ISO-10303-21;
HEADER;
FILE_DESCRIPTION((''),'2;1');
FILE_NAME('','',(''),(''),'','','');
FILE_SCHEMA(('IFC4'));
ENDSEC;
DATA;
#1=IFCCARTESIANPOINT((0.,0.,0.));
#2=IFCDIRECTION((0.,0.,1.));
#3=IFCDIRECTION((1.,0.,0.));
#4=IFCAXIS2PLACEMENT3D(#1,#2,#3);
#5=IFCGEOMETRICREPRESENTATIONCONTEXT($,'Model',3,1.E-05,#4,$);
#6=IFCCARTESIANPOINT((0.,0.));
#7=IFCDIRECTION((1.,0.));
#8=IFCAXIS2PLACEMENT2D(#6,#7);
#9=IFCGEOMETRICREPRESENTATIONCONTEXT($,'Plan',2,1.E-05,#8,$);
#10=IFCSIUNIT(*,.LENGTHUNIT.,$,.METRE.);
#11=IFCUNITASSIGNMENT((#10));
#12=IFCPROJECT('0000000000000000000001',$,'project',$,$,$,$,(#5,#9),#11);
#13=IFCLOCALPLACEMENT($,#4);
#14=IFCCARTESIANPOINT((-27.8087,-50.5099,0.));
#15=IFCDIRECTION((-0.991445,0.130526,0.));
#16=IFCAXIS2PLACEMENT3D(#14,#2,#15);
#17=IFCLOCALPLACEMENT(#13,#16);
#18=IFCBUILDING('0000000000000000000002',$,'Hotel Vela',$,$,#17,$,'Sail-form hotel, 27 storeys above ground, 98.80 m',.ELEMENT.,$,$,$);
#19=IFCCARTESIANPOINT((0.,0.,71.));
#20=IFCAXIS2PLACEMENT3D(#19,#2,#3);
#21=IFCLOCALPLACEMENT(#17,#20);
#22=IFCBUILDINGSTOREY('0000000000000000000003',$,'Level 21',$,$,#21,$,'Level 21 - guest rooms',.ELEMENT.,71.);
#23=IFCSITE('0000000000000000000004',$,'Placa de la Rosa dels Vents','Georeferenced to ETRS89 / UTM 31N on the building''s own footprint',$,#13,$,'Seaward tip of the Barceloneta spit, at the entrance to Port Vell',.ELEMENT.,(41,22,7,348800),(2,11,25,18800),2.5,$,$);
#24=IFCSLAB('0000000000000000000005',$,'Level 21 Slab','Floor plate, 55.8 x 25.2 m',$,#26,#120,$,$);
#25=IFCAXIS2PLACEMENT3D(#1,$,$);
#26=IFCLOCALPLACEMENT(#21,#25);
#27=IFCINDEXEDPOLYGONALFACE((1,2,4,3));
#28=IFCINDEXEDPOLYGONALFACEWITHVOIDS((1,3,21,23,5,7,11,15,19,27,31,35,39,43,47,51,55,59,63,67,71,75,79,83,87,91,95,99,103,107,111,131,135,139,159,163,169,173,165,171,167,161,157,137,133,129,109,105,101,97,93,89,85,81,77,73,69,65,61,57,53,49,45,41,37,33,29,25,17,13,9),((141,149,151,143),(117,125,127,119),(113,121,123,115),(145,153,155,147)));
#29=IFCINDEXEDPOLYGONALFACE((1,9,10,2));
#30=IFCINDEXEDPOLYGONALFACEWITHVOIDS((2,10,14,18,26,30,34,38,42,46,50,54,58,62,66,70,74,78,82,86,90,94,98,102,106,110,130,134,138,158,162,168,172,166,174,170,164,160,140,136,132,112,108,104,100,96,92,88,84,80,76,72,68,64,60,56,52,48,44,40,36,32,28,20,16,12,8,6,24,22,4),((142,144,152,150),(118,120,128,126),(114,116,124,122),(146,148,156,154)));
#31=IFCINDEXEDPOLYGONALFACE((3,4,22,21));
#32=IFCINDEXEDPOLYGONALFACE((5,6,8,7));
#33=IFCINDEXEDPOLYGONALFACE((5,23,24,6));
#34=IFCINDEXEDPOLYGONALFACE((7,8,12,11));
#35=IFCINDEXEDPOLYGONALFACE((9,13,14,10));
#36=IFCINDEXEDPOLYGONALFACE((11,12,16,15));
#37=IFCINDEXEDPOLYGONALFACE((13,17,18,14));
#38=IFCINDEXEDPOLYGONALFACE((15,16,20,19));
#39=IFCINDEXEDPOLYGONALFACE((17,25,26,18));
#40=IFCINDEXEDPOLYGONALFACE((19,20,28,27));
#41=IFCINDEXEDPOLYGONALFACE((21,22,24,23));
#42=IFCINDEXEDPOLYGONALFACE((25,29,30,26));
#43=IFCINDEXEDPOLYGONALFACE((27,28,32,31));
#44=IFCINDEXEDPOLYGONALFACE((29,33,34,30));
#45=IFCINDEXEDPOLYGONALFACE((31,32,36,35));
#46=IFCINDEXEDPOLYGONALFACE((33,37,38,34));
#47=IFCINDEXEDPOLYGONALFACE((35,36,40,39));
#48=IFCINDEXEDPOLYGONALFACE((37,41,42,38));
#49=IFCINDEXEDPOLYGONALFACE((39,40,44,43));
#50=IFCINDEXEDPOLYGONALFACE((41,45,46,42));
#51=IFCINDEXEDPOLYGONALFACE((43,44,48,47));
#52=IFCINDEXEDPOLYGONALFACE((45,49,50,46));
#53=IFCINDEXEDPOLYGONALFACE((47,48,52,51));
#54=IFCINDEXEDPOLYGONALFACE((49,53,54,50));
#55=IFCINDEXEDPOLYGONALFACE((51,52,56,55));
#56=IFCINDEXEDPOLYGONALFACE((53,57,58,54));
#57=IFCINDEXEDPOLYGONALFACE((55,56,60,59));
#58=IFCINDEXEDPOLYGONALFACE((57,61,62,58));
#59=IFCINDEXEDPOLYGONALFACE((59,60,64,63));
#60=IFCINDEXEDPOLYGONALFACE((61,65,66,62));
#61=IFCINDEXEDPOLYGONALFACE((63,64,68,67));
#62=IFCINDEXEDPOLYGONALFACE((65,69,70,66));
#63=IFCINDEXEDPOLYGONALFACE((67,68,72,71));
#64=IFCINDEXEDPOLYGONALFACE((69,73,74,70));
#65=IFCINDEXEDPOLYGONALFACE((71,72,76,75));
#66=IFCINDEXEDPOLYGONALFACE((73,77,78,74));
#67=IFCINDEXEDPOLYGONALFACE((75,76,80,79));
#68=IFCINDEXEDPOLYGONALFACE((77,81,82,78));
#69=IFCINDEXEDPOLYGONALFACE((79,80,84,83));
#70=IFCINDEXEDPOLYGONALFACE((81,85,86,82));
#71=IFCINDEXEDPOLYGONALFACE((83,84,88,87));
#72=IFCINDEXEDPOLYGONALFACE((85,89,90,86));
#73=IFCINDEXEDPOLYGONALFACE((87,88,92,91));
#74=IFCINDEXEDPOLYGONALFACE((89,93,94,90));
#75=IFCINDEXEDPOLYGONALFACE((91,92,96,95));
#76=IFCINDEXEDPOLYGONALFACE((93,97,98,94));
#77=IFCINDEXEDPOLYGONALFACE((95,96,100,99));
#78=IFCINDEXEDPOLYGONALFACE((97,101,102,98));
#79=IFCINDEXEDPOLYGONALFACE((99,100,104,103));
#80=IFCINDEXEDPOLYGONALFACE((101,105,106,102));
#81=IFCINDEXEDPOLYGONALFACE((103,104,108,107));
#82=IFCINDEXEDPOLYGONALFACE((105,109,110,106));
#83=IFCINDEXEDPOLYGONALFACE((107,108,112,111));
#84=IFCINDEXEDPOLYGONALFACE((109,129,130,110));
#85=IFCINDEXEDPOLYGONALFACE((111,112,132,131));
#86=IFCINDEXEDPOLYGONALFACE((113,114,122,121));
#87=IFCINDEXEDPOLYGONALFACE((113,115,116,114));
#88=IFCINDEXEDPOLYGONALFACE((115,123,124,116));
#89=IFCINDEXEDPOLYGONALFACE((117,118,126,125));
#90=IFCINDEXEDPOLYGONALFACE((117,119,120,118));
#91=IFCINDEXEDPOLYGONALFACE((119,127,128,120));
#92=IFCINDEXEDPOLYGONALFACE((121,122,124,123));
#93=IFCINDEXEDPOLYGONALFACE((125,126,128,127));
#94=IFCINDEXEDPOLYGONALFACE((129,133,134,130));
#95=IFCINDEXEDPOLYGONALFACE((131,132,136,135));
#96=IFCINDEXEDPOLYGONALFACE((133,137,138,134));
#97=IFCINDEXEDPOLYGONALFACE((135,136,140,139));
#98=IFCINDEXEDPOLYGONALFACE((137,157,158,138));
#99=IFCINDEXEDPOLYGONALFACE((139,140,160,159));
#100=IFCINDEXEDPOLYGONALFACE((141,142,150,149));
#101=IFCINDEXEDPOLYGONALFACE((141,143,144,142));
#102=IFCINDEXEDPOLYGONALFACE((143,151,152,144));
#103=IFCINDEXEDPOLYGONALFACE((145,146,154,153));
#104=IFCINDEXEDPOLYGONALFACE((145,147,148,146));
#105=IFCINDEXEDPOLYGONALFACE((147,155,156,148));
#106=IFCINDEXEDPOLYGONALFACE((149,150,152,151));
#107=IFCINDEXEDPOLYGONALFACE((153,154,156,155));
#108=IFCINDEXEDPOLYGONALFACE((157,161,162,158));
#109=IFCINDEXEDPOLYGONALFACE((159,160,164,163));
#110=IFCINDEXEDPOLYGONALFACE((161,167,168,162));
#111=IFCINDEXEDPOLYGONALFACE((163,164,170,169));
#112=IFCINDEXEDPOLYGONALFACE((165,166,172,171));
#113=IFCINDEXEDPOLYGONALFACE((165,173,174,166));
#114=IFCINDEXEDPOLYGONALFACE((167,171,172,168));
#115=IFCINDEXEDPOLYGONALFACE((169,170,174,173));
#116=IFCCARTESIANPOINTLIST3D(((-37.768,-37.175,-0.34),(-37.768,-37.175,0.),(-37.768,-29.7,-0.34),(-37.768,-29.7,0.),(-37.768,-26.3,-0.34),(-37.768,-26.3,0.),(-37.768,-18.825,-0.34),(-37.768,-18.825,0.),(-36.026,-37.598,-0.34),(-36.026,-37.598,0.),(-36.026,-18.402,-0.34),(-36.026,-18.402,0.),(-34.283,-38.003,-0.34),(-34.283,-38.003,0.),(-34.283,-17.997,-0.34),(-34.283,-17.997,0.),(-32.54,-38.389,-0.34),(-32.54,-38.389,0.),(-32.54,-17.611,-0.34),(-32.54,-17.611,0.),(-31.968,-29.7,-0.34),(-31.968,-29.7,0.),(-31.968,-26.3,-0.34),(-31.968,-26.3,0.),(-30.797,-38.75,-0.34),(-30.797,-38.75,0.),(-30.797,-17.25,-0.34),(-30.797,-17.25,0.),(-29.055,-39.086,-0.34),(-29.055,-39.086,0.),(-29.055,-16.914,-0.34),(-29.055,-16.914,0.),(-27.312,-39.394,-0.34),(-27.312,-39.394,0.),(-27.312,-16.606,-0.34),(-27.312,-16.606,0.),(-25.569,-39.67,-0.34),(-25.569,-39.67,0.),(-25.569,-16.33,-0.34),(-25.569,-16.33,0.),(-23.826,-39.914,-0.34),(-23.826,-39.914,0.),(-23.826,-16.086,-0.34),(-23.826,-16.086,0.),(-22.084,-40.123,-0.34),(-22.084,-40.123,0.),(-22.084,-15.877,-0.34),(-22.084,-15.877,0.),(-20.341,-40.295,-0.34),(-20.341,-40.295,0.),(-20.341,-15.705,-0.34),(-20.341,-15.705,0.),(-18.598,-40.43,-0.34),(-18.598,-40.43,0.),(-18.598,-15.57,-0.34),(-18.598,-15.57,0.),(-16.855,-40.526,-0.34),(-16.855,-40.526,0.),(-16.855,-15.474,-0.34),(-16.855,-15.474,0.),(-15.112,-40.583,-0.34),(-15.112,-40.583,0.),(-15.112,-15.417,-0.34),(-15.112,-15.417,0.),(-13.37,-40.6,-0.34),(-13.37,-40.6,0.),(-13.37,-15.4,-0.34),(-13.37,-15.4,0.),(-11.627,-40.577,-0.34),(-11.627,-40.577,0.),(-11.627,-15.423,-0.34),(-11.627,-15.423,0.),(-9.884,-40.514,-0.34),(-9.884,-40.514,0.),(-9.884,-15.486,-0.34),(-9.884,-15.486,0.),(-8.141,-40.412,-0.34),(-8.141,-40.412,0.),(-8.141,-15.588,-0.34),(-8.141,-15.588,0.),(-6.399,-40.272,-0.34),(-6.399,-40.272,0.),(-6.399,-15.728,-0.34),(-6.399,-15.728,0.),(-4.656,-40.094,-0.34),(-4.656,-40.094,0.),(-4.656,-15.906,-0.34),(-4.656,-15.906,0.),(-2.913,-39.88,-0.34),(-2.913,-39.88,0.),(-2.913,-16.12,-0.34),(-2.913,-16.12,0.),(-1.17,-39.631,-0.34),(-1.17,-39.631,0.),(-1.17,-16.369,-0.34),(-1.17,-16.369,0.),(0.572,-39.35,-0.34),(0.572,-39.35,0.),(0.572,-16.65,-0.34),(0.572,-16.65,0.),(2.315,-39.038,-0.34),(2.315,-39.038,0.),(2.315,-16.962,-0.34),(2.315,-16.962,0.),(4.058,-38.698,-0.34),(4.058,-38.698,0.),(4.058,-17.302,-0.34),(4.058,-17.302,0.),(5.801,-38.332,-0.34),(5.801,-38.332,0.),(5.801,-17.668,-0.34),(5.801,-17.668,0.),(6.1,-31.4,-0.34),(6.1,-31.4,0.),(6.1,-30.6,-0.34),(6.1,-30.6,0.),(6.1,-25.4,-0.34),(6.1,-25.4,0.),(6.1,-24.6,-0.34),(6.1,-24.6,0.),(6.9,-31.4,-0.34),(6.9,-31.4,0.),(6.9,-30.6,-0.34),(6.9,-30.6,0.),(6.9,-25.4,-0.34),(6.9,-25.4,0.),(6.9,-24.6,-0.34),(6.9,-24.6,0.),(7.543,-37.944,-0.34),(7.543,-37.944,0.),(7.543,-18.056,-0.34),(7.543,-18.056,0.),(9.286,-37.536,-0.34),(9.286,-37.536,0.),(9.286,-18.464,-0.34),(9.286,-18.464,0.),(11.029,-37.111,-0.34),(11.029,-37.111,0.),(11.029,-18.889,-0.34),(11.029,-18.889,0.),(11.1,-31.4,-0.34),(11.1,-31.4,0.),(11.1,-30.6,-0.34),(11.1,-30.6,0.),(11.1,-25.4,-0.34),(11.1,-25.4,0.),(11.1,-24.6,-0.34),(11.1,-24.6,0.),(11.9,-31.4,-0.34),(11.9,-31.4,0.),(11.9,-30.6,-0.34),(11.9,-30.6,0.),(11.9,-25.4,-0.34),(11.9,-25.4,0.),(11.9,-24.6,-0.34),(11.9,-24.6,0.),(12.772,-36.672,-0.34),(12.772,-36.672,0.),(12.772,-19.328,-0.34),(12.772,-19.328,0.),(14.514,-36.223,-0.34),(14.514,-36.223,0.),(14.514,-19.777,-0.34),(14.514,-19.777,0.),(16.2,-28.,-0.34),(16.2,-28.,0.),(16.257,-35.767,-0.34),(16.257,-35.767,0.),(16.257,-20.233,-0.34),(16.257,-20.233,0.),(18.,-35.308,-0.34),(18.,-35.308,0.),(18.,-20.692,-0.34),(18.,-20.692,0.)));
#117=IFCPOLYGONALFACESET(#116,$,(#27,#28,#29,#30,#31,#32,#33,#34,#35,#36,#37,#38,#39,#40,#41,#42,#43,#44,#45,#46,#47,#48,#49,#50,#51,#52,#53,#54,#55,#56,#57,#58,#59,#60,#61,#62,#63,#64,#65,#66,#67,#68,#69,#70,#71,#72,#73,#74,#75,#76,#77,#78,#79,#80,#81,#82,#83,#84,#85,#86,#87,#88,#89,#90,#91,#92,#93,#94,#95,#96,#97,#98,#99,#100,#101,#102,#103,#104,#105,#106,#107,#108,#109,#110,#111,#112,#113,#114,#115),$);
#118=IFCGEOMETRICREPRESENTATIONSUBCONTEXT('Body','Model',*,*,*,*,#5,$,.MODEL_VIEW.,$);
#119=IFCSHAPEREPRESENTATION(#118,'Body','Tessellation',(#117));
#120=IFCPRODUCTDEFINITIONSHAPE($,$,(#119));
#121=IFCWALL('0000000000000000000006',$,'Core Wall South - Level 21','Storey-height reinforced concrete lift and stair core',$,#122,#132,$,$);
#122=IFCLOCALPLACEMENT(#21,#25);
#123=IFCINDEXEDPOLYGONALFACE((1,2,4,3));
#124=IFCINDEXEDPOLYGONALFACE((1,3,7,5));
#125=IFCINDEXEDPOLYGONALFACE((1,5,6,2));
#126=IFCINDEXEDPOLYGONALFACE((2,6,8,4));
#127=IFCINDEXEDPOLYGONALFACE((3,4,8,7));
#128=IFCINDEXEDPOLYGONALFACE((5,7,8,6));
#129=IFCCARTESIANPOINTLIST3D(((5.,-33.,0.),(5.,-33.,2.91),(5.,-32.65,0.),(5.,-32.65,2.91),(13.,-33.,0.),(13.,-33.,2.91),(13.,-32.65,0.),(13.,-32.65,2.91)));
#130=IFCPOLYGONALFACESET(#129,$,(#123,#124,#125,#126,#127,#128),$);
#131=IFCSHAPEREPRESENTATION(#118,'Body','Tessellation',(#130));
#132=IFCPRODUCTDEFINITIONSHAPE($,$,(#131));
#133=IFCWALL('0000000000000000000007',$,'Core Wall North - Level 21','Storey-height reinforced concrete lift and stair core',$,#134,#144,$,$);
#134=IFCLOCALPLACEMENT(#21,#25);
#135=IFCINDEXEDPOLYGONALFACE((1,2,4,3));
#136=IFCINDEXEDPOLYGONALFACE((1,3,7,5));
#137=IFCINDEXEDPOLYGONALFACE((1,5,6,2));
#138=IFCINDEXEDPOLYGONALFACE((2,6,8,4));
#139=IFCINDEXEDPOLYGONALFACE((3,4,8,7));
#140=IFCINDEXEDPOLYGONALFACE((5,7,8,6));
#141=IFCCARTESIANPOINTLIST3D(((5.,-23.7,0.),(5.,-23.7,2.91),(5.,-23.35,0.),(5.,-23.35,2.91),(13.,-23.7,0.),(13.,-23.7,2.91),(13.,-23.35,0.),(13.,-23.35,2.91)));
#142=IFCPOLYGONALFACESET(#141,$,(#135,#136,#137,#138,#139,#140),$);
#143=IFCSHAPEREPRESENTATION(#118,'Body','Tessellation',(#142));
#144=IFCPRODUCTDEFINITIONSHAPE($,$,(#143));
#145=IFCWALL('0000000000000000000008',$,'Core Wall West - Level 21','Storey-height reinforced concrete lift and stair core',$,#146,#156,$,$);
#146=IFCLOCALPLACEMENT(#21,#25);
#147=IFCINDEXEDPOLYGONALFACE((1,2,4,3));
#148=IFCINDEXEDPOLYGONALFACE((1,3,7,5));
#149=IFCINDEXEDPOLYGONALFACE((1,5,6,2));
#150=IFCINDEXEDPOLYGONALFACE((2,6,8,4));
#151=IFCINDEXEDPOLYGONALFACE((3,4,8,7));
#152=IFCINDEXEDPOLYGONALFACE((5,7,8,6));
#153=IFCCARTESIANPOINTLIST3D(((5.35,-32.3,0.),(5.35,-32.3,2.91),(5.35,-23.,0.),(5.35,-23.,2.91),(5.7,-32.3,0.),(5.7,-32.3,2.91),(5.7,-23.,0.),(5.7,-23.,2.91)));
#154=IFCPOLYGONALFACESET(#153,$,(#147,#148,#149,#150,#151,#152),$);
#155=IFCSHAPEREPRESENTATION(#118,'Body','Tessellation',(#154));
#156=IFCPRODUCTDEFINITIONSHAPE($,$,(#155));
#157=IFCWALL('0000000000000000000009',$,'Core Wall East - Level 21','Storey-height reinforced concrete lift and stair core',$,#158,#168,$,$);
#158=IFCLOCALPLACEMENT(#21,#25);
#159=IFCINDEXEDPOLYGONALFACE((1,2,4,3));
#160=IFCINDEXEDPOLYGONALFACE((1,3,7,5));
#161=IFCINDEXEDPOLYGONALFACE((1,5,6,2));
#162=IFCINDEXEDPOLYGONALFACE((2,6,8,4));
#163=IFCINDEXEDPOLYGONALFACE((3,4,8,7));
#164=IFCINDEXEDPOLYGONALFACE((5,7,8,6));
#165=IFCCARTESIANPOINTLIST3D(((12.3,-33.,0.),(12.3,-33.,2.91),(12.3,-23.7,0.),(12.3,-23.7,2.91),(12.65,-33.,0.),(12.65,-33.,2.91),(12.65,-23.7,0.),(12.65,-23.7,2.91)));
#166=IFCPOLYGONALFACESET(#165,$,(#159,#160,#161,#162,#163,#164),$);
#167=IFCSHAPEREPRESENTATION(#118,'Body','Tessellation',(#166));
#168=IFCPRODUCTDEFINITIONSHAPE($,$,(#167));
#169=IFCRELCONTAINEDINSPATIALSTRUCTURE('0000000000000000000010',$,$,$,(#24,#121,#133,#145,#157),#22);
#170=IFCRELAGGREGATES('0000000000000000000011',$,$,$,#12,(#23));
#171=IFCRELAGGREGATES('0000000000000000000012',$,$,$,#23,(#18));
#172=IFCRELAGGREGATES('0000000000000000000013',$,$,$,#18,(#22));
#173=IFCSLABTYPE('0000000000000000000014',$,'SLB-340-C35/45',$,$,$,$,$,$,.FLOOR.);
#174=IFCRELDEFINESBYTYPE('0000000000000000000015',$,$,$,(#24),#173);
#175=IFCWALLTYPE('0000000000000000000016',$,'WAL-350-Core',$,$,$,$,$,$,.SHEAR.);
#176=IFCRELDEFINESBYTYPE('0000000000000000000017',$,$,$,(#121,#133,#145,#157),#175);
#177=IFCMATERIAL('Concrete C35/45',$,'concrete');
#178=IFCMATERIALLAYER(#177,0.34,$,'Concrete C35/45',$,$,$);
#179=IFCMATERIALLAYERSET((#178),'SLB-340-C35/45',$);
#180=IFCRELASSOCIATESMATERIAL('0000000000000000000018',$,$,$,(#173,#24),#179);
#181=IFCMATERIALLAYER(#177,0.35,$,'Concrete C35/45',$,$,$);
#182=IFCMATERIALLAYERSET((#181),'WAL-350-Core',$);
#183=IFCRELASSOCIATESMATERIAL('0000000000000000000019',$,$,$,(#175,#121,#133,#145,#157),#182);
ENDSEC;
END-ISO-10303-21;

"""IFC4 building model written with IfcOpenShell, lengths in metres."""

from ifc_helpers import new_model, si_unit, frame, origin_with_axes, origin_2d_with_axis, place, context, subcontext, project, spatial, line, indexed_curve, outline, extrude, material, layer, layer_set, layer_usage, type_object, element, save


model = new_model("IFC4")

# Units and contexts
model_context = context("Model", 3, precision=1e-05, world=origin_with_axes())
plan_context = context("Plan", 2, precision=1e-05, world=origin_2d_with_axis())
body_context = subcontext(model_context, "Body", "Model", "MODEL_VIEW")
ifc_project = project(units=[si_unit("LENGTHUNIT", "METRE")], contexts=[model_context, plan_context])

# Site, building, storey
site_placement = place(None, origin_with_axes())
site = spatial("IfcSite", under=ifc_project, at=site_placement, Name="Placa de la Rosa dels Vents", Description="Georeferenced to ETRS89 / UTM 31N on the building's own footprint", LongName="Seaward tip of the Barceloneta spit, at the entrance to Port Vell", CompositionType="ELEMENT", RefLatitude=(41, 22, 7, 348800), RefLongitude=(2, 11, 25, 18800), RefElevation=2.5)
building_placement = place(site_placement, frame((-27.8087, -50.5099, 0.0), z_axis=(0.0, 0.0, 1.0), x_axis=(-0.991445, 0.130526, 0.0)))
building = spatial("IfcBuilding", under=site, at=building_placement, Name="Hotel Vela", LongName="Sail-form hotel, 27 storeys above ground, 98.80 m", CompositionType="ELEMENT")
storey_placement = place(building_placement, frame((0.0, 0.0, 71.0), z_axis=(0.0, 0.0, 1.0), x_axis=(1.0, 0.0, 0.0)))
storey = spatial("IfcBuildingStorey", under=building, at=storey_placement, Name="Level 21", LongName="Level 21 - guest rooms", CompositionType="ELEMENT", Elevation=71.0)

# Shared definitions
ifc_material = material(Name="Concrete C35/45", Category="concrete")

# Slab, openings
ifc_layer_1 = layer(ifc_material, 0.34, Name="Concrete C35/45")
ifc_layer_set_1 = layer_set([ifc_layer_1], Name="SLB-340-C35/45")
ifc_layer_usage_1 = layer_usage(ifc_layer_set_1, "AXIS3", "POSITIVE", 0.0)
slab_type = type_object("IfcSlabType", Name="SLB-340-C35/45", PredefinedType="FLOOR", material=ifc_layer_set_1)
slab_placement = place(storey_placement, frame((0.0, 0.0, -0.34), z_axis=(0.0, 0.0, 1.0), x_axis=(1.0, 0.0, 0.0)))
slab = element("IfcSlab", 1, at=slab_placement, inside=storey, type_object=slab_type, material=ifc_layer_usage_1, Name="Level 21 Slab", Description="Floor plate, 55.8 x 25.2 m", context=body_context, shape_type="SweptSolid", body=[
    extrude(outline(indexed_curve([(-37.768, -37.175), (-36.026, -37.598), (-34.283, -38.003), (-32.54, -38.389), (-30.797, -38.75), (-29.055, -39.086), (-27.312, -39.394), (-25.569, -39.67), (-23.826, -39.914), (-22.084, -40.123), (-20.341, -40.295), (-18.598, -40.43), (-16.855, -40.526), (-15.112, -40.583), (-13.37, -40.6), (-11.627, -40.577), (-9.884, -40.514), (-8.141, -40.412), (-6.399, -40.272), (-4.656, -40.094), (-2.913, -39.88), (-1.17, -39.631), (0.572, -39.35), (2.315, -39.038), (4.058, -38.698), (5.801, -38.332), (7.543, -37.944), (9.286, -37.536), (11.029, -37.111), (12.772, -36.672), (14.514, -36.223), (16.257, -35.767), (18.0, -35.308), (16.2, -28.0), (18.0, -20.692), (16.257, -20.233), (14.514, -19.777), (12.772, -19.328), (11.029, -18.889), (9.286, -18.464), (7.543, -18.056), (5.801, -17.668), (4.058, -17.302), (2.315, -16.962), (0.572, -16.65), (-1.17, -16.369), (-2.913, -16.12), (-4.656, -15.906), (-6.399, -15.728), (-8.141, -15.588), (-9.884, -15.486), (-11.627, -15.423), (-13.37, -15.4), (-15.112, -15.417), (-16.855, -15.474), (-18.598, -15.57), (-20.341, -15.705), (-22.084, -15.877), (-23.826, -16.086), (-25.569, -16.33), (-27.312, -16.606), (-29.055, -16.914), (-30.797, -17.25), (-32.54, -17.611), (-34.283, -17.997), (-36.026, -18.402), (-37.768, -18.825), (-37.768, -26.3), (-31.968, -26.3), (-31.968, -29.7), (-37.768, -29.7)], segments=[line(1, 2, 3, 4, 5, 6, 7, 8, 9, 10, 11, 12, 13, 14, 15, 16, 17, 18, 19, 20, 21, 22, 23, 24, 25, 26, 27, 28, 29, 30, 31, 32, 33, 34, 35, 36, 37, 38, 39, 40, 41, 42, 43, 44, 45, 46, 47, 48, 49, 50, 51, 52, 53, 54, 55, 56, 57, 58, 59, 60, 61, 62, 63, 64, 65, 66, 67, 68, 69, 70, 71, 1)])), origin_with_axes(), (0.0, 0.0, 1.0), 0.34),
])
opening_1_placement = place(slab_placement, frame((6.1, -31.4, -0.05), z_axis=(0.0, 0.0, 1.0), x_axis=(1.0, 0.0, 0.0)))
element("IfcOpeningElement", 2, at=opening_1_placement, cuts=slab, PredefinedType="OPENING", context=body_context, shape_type="SweptSolid", body=[
    extrude(outline(indexed_curve([(0.0, 0.0), (0.8, 0.0), (0.8, 0.8), (0.0, 0.8)], segments=[line(1, 2, 3, 4, 1)])), origin_with_axes(), (0.0, 0.0, 1.0), 0.44),
])
opening_2_placement = place(slab_placement, frame((6.1, -25.4, -0.05), z_axis=(0.0, 0.0, 1.0), x_axis=(1.0, 0.0, 0.0)))
element("IfcOpeningElement", 3, at=opening_2_placement, cuts=slab, PredefinedType="OPENING", context=body_context, shape_type="SweptSolid", body=[
    extrude(outline(indexed_curve([(0.0, 0.0), (0.8, 0.0), (0.8, 0.8), (0.0, 0.8)], segments=[line(1, 2, 3, 4, 1)])), origin_with_axes(), (0.0, 0.0, 1.0), 0.44),
])
opening_3_placement = place(slab_placement, frame((11.1, -31.4, -0.05), z_axis=(0.0, 0.0, 1.0), x_axis=(1.0, 0.0, 0.0)))
element("IfcOpeningElement", 4, at=opening_3_placement, cuts=slab, PredefinedType="OPENING", context=body_context, shape_type="SweptSolid", body=[
    extrude(outline(indexed_curve([(0.0, 0.0), (0.8, 0.0), (0.8, 0.8), (0.0, 0.8)], segments=[line(1, 2, 3, 4, 1)])), origin_with_axes(), (0.0, 0.0, 1.0), 0.44),
])
opening_4_placement = place(slab_placement, frame((11.1, -25.4, -0.05), z_axis=(0.0, 0.0, 1.0), x_axis=(1.0, 0.0, 0.0)))
element("IfcOpeningElement", 5, at=opening_4_placement, cuts=slab, PredefinedType="OPENING", context=body_context, shape_type="SweptSolid", body=[
    extrude(outline(indexed_curve([(0.0, 0.0), (0.8, 0.0), (0.8, 0.8), (0.0, 0.8)], segments=[line(1, 2, 3, 4, 1)])), origin_with_axes(), (0.0, 0.0, 1.0), 0.44),
])

# Walls
ifc_layer_2 = layer(ifc_material, 0.35, Name="Concrete C35/45")
ifc_layer_set_2 = layer_set([ifc_layer_2], Name="WAL-350-Core")
ifc_layer_usage_2 = layer_usage(ifc_layer_set_2, "AXIS2", "POSITIVE", 0.0)
wall_type = type_object("IfcWallType", Name="WAL-350-Core", PredefinedType="SHEAR", material=ifc_layer_set_2)
wall_1_placement = place(storey_placement, frame((5.0, -33.0, 0.0), z_axis=(0.0, 0.0, 1.0), x_axis=(1.0, 0.0, 0.0)))
element("IfcWall", 6, at=wall_1_placement, inside=storey, type_object=wall_type, material=ifc_layer_usage_2, Name="Core Wall South - Level 21", Description="Storey-height reinforced concrete lift and stair core", context=body_context, shape_type="SweptSolid", body=[
    extrude(outline(indexed_curve([(0.0, 0.0), (8.0, 0.0), (8.0, 0.35), (0.0, 0.35)], segments=[line(1, 2, 3, 4, 1)])), origin_with_axes(), (0.0, 0.0, 1.0), 2.91),
])
ifc_layer_usage_3 = layer_usage(ifc_layer_set_2, "AXIS2", "POSITIVE", 0.0)
wall_2_placement = place(storey_placement, frame((13.0, -23.35, 0.0), z_axis=(0.0, 0.0, 1.0), x_axis=(-1.0, 0.0, 0.0)))
element("IfcWall", 7, at=wall_2_placement, inside=storey, type_object=wall_type, material=ifc_layer_usage_3, Name="Core Wall North - Level 21", Description="Storey-height reinforced concrete lift and stair core", context=body_context, shape_type="SweptSolid", body=[
    extrude(outline(indexed_curve([(0.0, 0.0), (8.0, 0.0), (8.0, 0.35), (0.0, 0.35)], segments=[line(1, 2, 3, 4, 1)])), origin_with_axes(), (0.0, 0.0, 1.0), 2.91),
])
ifc_layer_usage_4 = layer_usage(ifc_layer_set_2, "AXIS2", "POSITIVE", 0.0)
wall_3_placement = place(storey_placement, frame((5.35, -23.0, 0.0), z_axis=(0.0, 0.0, 1.0), x_axis=(0.0, -1.0, 0.0)))
element("IfcWall", 8, at=wall_3_placement, inside=storey, type_object=wall_type, material=ifc_layer_usage_4, Name="Core Wall West - Level 21", Description="Storey-height reinforced concrete lift and stair core", context=body_context, shape_type="SweptSolid", body=[
    extrude(outline(indexed_curve([(0.0, 0.0), (9.3, 0.0), (9.3, 0.35), (0.0, 0.35)], segments=[line(1, 2, 3, 4, 1)])), origin_with_axes(), (0.0, 0.0, 1.0), 2.91),
])
ifc_layer_usage_5 = layer_usage(ifc_layer_set_2, "AXIS2", "POSITIVE", 0.0)
wall_4_placement = place(storey_placement, frame((12.65, -33.0, 0.0), z_axis=(0.0, 0.0, 1.0), x_axis=(0.0, 1.0, 0.0)))
element("IfcWall", 9, at=wall_4_placement, inside=storey, type_object=wall_type, material=ifc_layer_usage_5, Name="Core Wall East - Level 21", Description="Storey-height reinforced concrete lift and stair core", context=body_context, shape_type="SweptSolid", body=[
    extrude(outline(indexed_curve([(0.0, 0.0), (9.3, 0.0), (9.3, 0.35), (0.0, 0.35)], segments=[line(1, 2, 3, 4, 1)])), origin_with_axes(), (0.0, 0.0, 1.0), 2.91),
])

save(model, "model.ifc")
